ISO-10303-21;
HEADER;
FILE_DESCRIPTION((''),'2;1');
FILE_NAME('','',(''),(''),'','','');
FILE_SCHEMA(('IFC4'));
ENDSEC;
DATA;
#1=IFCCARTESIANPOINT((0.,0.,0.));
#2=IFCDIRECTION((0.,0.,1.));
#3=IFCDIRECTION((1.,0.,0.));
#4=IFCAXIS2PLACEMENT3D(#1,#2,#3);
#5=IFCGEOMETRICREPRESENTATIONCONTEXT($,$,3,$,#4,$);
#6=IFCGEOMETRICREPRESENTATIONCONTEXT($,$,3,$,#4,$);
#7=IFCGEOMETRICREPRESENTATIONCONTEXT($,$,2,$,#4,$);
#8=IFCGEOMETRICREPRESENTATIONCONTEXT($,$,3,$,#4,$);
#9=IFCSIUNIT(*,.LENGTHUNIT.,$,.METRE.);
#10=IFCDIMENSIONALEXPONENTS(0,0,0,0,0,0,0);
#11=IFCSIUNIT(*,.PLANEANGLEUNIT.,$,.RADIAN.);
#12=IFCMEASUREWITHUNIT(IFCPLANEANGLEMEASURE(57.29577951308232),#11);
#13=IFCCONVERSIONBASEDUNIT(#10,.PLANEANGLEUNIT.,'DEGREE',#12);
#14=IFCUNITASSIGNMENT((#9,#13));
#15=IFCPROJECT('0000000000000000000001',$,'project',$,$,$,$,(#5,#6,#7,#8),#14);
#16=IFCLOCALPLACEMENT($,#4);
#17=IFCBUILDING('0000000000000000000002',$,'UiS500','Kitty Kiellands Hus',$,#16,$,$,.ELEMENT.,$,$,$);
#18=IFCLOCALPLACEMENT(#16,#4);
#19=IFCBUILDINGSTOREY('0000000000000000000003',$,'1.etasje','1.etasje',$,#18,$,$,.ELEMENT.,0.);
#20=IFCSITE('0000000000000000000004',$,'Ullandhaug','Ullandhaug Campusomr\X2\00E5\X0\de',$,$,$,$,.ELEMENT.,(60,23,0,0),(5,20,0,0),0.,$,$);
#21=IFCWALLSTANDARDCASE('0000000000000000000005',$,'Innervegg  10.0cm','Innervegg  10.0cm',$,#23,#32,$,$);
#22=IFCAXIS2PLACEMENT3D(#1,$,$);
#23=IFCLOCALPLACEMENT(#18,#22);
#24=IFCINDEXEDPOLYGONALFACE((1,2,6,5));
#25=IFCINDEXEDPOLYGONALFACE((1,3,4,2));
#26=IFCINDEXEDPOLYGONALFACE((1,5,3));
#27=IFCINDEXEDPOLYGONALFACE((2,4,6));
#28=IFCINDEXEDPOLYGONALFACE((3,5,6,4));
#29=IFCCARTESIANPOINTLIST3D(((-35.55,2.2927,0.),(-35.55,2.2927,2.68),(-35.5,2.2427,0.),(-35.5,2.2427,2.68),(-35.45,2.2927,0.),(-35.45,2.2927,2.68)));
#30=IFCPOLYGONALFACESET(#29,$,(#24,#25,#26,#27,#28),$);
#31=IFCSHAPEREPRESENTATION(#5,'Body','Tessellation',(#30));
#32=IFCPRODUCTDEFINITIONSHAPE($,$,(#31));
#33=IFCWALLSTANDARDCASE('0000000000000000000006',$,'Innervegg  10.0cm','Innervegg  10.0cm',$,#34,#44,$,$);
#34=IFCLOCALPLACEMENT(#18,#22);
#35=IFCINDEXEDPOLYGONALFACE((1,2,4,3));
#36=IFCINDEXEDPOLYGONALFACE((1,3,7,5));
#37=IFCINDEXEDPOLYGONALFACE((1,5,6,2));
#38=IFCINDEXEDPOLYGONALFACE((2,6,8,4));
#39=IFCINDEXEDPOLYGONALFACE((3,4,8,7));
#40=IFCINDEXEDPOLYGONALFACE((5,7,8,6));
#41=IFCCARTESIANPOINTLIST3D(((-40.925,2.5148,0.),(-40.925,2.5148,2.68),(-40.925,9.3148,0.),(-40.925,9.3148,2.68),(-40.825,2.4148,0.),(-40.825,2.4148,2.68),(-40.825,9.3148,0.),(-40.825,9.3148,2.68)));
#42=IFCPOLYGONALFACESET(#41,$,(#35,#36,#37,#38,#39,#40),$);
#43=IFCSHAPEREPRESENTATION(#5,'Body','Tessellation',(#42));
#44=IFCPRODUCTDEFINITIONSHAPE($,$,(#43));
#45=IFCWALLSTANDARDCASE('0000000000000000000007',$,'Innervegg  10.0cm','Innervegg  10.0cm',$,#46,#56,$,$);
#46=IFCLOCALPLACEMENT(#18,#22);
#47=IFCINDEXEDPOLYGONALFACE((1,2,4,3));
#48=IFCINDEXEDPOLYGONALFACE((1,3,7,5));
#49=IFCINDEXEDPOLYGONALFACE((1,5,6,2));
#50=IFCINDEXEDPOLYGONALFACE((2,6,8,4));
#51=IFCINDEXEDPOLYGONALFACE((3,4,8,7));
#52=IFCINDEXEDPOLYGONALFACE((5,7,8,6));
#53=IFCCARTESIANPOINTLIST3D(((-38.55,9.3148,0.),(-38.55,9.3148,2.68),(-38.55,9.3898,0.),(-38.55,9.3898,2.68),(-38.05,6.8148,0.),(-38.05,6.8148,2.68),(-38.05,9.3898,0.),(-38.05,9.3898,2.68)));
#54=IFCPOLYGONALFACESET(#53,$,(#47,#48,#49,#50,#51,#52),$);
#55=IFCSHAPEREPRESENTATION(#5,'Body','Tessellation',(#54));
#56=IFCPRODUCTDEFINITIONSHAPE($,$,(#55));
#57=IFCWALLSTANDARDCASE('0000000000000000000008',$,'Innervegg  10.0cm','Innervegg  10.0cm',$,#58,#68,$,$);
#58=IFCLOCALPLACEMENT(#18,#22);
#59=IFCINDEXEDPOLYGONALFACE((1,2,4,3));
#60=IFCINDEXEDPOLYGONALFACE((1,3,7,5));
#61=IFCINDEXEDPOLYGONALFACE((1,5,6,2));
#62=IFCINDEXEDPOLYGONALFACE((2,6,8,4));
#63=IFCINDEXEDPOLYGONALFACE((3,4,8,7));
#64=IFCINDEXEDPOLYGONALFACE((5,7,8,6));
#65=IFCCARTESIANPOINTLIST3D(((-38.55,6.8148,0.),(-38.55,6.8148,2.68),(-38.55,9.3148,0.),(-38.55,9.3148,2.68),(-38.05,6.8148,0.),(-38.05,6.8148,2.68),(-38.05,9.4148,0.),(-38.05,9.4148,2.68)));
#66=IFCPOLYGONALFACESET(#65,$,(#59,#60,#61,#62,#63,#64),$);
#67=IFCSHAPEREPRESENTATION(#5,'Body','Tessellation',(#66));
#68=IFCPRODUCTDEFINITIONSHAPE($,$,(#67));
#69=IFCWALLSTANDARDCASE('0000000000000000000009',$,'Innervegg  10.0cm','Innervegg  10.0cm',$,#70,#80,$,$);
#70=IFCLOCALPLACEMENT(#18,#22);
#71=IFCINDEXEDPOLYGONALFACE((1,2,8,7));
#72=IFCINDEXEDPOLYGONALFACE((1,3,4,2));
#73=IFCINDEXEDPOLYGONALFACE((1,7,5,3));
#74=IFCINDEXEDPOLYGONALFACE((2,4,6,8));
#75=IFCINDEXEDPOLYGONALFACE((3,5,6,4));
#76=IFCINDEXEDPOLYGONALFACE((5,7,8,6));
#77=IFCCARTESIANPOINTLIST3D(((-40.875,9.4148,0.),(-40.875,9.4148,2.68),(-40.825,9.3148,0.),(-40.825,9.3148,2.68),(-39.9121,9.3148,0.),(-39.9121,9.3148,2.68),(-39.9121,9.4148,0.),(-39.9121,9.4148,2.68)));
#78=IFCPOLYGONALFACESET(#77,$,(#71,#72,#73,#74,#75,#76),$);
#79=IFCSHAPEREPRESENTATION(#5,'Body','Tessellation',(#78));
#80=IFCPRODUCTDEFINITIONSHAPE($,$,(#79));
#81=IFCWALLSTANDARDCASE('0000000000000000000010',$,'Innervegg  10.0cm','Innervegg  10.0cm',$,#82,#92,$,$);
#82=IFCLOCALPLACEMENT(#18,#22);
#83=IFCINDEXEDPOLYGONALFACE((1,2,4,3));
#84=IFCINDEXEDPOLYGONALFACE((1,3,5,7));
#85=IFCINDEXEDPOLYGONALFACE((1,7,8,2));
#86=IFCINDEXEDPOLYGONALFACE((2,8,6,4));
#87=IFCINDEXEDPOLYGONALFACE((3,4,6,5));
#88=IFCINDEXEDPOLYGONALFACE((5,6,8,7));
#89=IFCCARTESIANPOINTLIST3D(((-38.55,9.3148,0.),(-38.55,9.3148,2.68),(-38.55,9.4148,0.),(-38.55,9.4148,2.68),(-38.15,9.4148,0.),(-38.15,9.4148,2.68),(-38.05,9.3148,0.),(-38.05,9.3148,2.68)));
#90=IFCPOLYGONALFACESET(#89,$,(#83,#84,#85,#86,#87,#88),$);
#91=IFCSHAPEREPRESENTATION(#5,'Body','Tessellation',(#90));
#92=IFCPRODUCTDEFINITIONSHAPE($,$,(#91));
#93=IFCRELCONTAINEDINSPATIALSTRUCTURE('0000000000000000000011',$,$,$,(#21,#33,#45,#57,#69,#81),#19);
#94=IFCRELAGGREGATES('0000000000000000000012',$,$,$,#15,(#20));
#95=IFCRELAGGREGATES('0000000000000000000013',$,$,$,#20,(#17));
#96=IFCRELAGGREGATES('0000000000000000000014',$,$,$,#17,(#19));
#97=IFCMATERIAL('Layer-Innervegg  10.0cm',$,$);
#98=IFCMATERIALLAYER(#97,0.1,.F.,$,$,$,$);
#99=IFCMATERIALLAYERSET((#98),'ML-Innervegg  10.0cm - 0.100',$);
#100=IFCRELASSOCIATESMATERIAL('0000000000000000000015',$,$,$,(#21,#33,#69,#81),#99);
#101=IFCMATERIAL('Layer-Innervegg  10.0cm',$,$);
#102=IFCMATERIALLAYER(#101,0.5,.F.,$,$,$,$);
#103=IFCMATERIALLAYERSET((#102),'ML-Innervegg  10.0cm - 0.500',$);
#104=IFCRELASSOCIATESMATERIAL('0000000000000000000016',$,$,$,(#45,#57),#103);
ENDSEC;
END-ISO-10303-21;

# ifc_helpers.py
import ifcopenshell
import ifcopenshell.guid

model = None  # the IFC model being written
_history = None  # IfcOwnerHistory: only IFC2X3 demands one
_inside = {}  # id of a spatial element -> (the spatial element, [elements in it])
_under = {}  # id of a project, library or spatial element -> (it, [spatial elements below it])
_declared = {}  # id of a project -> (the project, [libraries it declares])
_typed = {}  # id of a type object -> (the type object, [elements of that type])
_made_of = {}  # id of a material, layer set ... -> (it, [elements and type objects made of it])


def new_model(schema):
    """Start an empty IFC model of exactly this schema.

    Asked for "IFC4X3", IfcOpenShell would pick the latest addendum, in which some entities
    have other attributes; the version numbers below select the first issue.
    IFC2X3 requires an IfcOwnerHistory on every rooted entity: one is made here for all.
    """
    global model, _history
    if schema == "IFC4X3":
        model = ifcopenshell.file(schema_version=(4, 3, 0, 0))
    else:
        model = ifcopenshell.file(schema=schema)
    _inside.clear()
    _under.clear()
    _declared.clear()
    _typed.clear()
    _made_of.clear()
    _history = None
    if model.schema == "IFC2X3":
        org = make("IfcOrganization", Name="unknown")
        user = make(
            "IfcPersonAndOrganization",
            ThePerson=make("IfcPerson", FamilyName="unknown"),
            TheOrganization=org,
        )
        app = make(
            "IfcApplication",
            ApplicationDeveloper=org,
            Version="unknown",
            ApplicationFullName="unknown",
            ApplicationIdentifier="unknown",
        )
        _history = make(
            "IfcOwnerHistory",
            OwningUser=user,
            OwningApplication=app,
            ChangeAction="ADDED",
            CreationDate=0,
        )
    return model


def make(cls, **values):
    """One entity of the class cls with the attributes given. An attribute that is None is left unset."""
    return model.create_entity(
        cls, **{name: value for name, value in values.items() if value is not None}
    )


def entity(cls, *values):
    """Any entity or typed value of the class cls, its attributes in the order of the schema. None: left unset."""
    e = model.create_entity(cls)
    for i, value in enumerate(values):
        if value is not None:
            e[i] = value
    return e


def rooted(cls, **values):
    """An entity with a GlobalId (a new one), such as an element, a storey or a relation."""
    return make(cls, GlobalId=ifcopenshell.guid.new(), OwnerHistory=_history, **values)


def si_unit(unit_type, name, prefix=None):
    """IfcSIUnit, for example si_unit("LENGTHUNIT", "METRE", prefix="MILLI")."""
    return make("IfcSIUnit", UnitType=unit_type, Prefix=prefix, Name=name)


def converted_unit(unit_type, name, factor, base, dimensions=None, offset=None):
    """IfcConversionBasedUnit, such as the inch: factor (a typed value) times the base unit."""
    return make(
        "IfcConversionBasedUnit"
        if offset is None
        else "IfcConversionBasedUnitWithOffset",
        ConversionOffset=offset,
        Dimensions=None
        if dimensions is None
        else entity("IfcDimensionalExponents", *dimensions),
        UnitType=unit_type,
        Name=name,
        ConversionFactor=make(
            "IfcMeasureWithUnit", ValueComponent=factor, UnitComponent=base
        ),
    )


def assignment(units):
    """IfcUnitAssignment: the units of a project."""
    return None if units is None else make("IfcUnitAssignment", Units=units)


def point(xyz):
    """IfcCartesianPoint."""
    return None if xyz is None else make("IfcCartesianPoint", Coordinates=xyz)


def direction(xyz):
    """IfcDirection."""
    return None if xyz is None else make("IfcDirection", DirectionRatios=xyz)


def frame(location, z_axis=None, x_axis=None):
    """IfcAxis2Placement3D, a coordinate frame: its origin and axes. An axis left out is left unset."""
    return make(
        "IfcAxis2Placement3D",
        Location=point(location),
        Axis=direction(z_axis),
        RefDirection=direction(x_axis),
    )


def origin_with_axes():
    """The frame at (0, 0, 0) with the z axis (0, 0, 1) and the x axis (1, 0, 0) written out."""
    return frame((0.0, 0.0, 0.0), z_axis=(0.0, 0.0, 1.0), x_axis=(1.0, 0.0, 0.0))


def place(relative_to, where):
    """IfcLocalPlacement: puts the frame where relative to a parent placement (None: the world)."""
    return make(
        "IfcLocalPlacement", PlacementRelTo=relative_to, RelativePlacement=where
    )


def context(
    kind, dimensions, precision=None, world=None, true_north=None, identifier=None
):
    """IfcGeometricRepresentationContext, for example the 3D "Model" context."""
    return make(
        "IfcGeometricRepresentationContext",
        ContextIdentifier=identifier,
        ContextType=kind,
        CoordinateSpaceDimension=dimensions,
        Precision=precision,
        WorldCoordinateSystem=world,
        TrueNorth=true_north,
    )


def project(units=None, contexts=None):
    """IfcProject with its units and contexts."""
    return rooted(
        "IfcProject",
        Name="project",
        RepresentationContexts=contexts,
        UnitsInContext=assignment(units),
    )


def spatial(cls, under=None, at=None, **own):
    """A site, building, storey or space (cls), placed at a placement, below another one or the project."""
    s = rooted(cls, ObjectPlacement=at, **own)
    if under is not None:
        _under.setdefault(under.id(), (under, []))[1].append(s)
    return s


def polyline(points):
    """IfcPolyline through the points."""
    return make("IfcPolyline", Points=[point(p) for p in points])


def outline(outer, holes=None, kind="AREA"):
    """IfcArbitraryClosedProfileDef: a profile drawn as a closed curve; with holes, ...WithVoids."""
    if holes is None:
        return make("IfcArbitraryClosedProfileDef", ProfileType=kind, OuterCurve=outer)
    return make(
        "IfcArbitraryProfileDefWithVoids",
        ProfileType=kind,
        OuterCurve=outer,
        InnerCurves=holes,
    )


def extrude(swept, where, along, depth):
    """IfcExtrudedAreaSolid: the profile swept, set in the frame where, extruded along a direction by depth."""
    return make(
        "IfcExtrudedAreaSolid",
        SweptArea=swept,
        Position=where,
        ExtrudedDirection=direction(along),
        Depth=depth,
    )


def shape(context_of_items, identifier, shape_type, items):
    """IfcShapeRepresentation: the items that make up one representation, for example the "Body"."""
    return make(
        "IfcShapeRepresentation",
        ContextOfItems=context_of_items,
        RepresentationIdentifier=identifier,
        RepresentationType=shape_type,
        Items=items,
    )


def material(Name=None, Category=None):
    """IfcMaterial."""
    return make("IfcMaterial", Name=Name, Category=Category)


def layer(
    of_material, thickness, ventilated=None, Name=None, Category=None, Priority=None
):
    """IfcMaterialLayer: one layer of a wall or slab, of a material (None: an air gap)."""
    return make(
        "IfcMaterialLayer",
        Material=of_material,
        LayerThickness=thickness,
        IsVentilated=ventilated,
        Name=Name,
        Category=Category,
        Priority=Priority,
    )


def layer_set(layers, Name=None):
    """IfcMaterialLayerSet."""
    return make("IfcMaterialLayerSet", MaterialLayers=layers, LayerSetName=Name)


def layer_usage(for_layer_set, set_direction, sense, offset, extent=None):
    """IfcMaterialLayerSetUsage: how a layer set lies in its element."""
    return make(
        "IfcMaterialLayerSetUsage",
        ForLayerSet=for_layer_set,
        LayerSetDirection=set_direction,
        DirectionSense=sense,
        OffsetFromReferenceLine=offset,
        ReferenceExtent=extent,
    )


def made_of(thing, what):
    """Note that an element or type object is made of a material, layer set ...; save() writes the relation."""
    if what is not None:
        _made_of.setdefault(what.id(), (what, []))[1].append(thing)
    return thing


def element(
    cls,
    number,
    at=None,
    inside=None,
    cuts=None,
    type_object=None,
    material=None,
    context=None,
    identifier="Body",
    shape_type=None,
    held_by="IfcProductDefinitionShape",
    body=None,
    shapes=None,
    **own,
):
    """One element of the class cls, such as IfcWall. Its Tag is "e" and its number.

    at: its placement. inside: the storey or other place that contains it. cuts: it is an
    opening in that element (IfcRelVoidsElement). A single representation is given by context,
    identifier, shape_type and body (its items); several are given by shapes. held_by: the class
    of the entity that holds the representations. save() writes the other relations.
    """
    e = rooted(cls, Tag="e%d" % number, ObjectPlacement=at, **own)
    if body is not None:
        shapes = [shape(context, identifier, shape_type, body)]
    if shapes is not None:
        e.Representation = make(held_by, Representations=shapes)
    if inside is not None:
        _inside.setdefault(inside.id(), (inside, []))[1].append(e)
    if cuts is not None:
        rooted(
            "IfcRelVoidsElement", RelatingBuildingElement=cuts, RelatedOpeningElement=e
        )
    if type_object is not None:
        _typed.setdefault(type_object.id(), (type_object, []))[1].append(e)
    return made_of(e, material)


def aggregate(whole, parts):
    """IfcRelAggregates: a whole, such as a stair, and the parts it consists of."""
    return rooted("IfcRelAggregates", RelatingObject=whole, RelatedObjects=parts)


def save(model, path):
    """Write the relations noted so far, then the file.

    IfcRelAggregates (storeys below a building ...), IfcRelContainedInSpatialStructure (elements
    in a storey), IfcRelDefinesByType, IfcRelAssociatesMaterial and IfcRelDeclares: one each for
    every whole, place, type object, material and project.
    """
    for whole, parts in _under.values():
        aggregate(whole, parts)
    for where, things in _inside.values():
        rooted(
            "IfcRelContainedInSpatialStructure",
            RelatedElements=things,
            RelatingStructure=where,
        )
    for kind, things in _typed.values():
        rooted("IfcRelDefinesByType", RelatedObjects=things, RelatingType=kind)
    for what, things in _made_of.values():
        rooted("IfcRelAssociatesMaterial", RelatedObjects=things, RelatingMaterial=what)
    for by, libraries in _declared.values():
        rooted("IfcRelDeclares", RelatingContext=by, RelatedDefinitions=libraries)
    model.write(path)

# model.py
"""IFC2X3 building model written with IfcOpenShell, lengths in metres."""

from ifc_helpers import new_model, entity, si_unit, converted_unit, frame, origin_with_axes, place, context, project, spatial, polyline, outline, extrude, material, layer, layer_set, layer_usage, element, save


model = new_model("IFC2X3")

# Units and contexts
context_of_model_1 = context(None, 3, world=origin_with_axes())
context_of_model_2 = context(None, 3, world=origin_with_axes())
context_of_model_3 = context(None, 2, world=origin_with_axes())
context_of_model_4 = context(None, 3, world=origin_with_axes())
ifc_project = project(units=[si_unit("LENGTHUNIT", "METRE"), converted_unit("PLANEANGLEUNIT", "DEGREE", entity("IfcPlaneAngleMeasure", 57.29577951308232), si_unit("PLANEANGLEUNIT", "RADIAN"), dimensions=[0, 0, 0, 0, 0, 0, 0])], contexts=[context_of_model_1, context_of_model_2, context_of_model_3, context_of_model_4])

# Site, building, storey
site = spatial("IfcSite", under=ifc_project, Name="Ullandhaug", Description="Ullandhaug Campusområde", CompositionType="ELEMENT", RefLatitude=(60, 23, 0, 0), RefLongitude=(5, 20, 0, 0), RefElevation=0.0)
building_placement = place(None, origin_with_axes())
building = spatial("IfcBuilding", under=site, at=building_placement, Name="UiS500", Description="Kitty Kiellands Hus", CompositionType="ELEMENT")
storey_placement = place(building_placement, origin_with_axes())
storey = spatial("IfcBuildingStorey", under=building, at=storey_placement, Name="1.etasje", Description="1.etasje", CompositionType="ELEMENT", Elevation=0.0)

# Shared definitions
ifc_material_1 = material(Name="Layer-Innervegg  10.0cm")
ifc_layer_1 = layer(ifc_material_1, 0.1, ventilated=False)
ifc_layer_set_1 = layer_set([ifc_layer_1], Name="ML-Innervegg  10.0cm - 0.100")
ifc_layer_usage_1 = layer_usage(ifc_layer_set_1, "AXIS2", "POSITIVE", 0.0)

# Walls
wall_1_placement = place(storey_placement, frame((-35.55, 2.2927, 0.0), z_axis=(0.0, 0.0, 1.0), x_axis=(1.0, 0.0, 0.0)))
element("IfcWallStandardCase", 1, at=wall_1_placement, inside=storey, material=ifc_layer_usage_1, Name="Innervegg  10.0cm", Description="Innervegg  10.0cm", context=context_of_model_1, shape_type="SweptSolid", body=[
    extrude(outline(polyline([(0.0, 0.0), (0.1, 0.0), (0.0, 0.1), (0.1, 0.1), (0.0, 0.0)])), frame((0.0, 0.0, 0.0), z_axis=(0.0, 0.0, -1.0), x_axis=(1.0, 0.0, 0.0)), (0.0, 0.0, -1.0), 2.68),
])
wall_2_placement = place(storey_placement, frame((-40.925, 9.3148, 0.0), z_axis=(0.0, 0.0, 1.0), x_axis=(0.0, -1.0, 0.0)))
element("IfcWallStandardCase", 2, at=wall_2_placement, inside=storey, material=ifc_layer_usage_1, Name="Innervegg  10.0cm", Description="Innervegg  10.0cm", context=context_of_model_1, shape_type="SweptSolid", body=[
    extrude(outline(polyline([(0.0, 0.0), (6.8, 0.0), (6.9, 0.1), (0.0, 0.1), (0.0, 0.0)])), frame((0.0, 0.0, 0.0), z_axis=(0.0, 0.0, 1.0), x_axis=(1.0, 0.0, 0.0)), (0.0, 0.0, 1.0), 2.68),
])
ifc_material_2 = material(Name="Layer-Innervegg  10.0cm")
ifc_layer_2 = layer(ifc_material_2, 0.5, ventilated=False)
ifc_layer_set_2 = layer_set([ifc_layer_2], Name="ML-Innervegg  10.0cm - 0.500")
ifc_layer_usage_2 = layer_usage(ifc_layer_set_2, "AXIS2", "POSITIVE", 0.0)
wall_3_placement = place(storey_placement, frame((-38.55, 9.3898, 0.0), z_axis=(0.0, 0.0, 1.0), x_axis=(0.0, -1.0, 0.0)))
element("IfcWallStandardCase", 3, at=wall_3_placement, inside=storey, material=ifc_layer_usage_2, Name="Innervegg  10.0cm", Description="Innervegg  10.0cm", context=context_of_model_1, shape_type="SweptSolid", body=[
    extrude(outline(polyline([(0.0, 0.0), (0.075, 0.0), (2.575, 0.5), (0.0, 0.5), (0.0, 0.0)])), frame((0.0, 0.0, 0.0), z_axis=(0.0, 0.0, 1.0), x_axis=(1.0, 0.0, 0.0)), (0.0, 0.0, 1.0), 2.68),
])
wall_4_placement = place(storey_placement, frame((-38.05, 6.8148, 0.0), z_axis=(0.0, 0.0, 1.0), x_axis=(0.0, 1.0, 0.0)))
element("IfcWallStandardCase", 4, at=wall_4_placement, inside=storey, material=ifc_layer_usage_2, Name="Innervegg  10.0cm", Description="Innervegg  10.0cm", context=context_of_model_1, shape_type="SweptSolid", body=[
    extrude(outline(polyline([(0.0, 0.0), (2.6, 0.0), (2.5, 0.5), (0.0, 0.5), (0.0, 0.0)])), frame((0.0, 0.0, 0.0), z_axis=(0.0, 0.0, 1.0), x_axis=(1.0, 0.0, 0.0)), (0.0, 0.0, 1.0), 2.68),
])
wall_5_placement = place(storey_placement, frame((-39.9121, 9.4148, 0.0), z_axis=(0.0, 0.0, 1.0), x_axis=(-1.0, 0.0, 0.0)))
element("IfcWallStandardCase", 5, at=wall_5_placement, inside=storey, material=ifc_layer_usage_1, Name="Innervegg  10.0cm", Description="Innervegg  10.0cm", context=context_of_model_1, shape_type="SweptSolid", body=[
    extrude(outline(polyline([(0.0, 0.0), (0.9629, 0.0), (0.9129, 0.1), (0.0, 0.1), (0.0, 0.0)])), frame((0.0, 0.0, 0.0), z_axis=(0.0, 0.0, 1.0), x_axis=(1.0, 0.0, 0.0)), (0.0, 0.0, 1.0), 2.68),
])
wall_6_placement = place(storey_placement, frame((-38.55, 9.3148, 0.0), z_axis=(0.0, 0.0, 1.0), x_axis=(1.0, 0.0, 0.0)))
element("IfcWallStandardCase", 6, at=wall_6_placement, inside=storey, material=ifc_layer_usage_1, Name="Innervegg  10.0cm", Description="Innervegg  10.0cm", context=context_of_model_1, shape_type="SweptSolid", body=[
    extrude(outline(polyline([(0.0, 0.0), (0.5, 0.0), (0.4, 0.1), (0.0, 0.1), (0.0, 0.0)])), origin_with_axes(), (0.0, 0.0, 1.0), 2.68),
])

save(model, "model.ifc")
